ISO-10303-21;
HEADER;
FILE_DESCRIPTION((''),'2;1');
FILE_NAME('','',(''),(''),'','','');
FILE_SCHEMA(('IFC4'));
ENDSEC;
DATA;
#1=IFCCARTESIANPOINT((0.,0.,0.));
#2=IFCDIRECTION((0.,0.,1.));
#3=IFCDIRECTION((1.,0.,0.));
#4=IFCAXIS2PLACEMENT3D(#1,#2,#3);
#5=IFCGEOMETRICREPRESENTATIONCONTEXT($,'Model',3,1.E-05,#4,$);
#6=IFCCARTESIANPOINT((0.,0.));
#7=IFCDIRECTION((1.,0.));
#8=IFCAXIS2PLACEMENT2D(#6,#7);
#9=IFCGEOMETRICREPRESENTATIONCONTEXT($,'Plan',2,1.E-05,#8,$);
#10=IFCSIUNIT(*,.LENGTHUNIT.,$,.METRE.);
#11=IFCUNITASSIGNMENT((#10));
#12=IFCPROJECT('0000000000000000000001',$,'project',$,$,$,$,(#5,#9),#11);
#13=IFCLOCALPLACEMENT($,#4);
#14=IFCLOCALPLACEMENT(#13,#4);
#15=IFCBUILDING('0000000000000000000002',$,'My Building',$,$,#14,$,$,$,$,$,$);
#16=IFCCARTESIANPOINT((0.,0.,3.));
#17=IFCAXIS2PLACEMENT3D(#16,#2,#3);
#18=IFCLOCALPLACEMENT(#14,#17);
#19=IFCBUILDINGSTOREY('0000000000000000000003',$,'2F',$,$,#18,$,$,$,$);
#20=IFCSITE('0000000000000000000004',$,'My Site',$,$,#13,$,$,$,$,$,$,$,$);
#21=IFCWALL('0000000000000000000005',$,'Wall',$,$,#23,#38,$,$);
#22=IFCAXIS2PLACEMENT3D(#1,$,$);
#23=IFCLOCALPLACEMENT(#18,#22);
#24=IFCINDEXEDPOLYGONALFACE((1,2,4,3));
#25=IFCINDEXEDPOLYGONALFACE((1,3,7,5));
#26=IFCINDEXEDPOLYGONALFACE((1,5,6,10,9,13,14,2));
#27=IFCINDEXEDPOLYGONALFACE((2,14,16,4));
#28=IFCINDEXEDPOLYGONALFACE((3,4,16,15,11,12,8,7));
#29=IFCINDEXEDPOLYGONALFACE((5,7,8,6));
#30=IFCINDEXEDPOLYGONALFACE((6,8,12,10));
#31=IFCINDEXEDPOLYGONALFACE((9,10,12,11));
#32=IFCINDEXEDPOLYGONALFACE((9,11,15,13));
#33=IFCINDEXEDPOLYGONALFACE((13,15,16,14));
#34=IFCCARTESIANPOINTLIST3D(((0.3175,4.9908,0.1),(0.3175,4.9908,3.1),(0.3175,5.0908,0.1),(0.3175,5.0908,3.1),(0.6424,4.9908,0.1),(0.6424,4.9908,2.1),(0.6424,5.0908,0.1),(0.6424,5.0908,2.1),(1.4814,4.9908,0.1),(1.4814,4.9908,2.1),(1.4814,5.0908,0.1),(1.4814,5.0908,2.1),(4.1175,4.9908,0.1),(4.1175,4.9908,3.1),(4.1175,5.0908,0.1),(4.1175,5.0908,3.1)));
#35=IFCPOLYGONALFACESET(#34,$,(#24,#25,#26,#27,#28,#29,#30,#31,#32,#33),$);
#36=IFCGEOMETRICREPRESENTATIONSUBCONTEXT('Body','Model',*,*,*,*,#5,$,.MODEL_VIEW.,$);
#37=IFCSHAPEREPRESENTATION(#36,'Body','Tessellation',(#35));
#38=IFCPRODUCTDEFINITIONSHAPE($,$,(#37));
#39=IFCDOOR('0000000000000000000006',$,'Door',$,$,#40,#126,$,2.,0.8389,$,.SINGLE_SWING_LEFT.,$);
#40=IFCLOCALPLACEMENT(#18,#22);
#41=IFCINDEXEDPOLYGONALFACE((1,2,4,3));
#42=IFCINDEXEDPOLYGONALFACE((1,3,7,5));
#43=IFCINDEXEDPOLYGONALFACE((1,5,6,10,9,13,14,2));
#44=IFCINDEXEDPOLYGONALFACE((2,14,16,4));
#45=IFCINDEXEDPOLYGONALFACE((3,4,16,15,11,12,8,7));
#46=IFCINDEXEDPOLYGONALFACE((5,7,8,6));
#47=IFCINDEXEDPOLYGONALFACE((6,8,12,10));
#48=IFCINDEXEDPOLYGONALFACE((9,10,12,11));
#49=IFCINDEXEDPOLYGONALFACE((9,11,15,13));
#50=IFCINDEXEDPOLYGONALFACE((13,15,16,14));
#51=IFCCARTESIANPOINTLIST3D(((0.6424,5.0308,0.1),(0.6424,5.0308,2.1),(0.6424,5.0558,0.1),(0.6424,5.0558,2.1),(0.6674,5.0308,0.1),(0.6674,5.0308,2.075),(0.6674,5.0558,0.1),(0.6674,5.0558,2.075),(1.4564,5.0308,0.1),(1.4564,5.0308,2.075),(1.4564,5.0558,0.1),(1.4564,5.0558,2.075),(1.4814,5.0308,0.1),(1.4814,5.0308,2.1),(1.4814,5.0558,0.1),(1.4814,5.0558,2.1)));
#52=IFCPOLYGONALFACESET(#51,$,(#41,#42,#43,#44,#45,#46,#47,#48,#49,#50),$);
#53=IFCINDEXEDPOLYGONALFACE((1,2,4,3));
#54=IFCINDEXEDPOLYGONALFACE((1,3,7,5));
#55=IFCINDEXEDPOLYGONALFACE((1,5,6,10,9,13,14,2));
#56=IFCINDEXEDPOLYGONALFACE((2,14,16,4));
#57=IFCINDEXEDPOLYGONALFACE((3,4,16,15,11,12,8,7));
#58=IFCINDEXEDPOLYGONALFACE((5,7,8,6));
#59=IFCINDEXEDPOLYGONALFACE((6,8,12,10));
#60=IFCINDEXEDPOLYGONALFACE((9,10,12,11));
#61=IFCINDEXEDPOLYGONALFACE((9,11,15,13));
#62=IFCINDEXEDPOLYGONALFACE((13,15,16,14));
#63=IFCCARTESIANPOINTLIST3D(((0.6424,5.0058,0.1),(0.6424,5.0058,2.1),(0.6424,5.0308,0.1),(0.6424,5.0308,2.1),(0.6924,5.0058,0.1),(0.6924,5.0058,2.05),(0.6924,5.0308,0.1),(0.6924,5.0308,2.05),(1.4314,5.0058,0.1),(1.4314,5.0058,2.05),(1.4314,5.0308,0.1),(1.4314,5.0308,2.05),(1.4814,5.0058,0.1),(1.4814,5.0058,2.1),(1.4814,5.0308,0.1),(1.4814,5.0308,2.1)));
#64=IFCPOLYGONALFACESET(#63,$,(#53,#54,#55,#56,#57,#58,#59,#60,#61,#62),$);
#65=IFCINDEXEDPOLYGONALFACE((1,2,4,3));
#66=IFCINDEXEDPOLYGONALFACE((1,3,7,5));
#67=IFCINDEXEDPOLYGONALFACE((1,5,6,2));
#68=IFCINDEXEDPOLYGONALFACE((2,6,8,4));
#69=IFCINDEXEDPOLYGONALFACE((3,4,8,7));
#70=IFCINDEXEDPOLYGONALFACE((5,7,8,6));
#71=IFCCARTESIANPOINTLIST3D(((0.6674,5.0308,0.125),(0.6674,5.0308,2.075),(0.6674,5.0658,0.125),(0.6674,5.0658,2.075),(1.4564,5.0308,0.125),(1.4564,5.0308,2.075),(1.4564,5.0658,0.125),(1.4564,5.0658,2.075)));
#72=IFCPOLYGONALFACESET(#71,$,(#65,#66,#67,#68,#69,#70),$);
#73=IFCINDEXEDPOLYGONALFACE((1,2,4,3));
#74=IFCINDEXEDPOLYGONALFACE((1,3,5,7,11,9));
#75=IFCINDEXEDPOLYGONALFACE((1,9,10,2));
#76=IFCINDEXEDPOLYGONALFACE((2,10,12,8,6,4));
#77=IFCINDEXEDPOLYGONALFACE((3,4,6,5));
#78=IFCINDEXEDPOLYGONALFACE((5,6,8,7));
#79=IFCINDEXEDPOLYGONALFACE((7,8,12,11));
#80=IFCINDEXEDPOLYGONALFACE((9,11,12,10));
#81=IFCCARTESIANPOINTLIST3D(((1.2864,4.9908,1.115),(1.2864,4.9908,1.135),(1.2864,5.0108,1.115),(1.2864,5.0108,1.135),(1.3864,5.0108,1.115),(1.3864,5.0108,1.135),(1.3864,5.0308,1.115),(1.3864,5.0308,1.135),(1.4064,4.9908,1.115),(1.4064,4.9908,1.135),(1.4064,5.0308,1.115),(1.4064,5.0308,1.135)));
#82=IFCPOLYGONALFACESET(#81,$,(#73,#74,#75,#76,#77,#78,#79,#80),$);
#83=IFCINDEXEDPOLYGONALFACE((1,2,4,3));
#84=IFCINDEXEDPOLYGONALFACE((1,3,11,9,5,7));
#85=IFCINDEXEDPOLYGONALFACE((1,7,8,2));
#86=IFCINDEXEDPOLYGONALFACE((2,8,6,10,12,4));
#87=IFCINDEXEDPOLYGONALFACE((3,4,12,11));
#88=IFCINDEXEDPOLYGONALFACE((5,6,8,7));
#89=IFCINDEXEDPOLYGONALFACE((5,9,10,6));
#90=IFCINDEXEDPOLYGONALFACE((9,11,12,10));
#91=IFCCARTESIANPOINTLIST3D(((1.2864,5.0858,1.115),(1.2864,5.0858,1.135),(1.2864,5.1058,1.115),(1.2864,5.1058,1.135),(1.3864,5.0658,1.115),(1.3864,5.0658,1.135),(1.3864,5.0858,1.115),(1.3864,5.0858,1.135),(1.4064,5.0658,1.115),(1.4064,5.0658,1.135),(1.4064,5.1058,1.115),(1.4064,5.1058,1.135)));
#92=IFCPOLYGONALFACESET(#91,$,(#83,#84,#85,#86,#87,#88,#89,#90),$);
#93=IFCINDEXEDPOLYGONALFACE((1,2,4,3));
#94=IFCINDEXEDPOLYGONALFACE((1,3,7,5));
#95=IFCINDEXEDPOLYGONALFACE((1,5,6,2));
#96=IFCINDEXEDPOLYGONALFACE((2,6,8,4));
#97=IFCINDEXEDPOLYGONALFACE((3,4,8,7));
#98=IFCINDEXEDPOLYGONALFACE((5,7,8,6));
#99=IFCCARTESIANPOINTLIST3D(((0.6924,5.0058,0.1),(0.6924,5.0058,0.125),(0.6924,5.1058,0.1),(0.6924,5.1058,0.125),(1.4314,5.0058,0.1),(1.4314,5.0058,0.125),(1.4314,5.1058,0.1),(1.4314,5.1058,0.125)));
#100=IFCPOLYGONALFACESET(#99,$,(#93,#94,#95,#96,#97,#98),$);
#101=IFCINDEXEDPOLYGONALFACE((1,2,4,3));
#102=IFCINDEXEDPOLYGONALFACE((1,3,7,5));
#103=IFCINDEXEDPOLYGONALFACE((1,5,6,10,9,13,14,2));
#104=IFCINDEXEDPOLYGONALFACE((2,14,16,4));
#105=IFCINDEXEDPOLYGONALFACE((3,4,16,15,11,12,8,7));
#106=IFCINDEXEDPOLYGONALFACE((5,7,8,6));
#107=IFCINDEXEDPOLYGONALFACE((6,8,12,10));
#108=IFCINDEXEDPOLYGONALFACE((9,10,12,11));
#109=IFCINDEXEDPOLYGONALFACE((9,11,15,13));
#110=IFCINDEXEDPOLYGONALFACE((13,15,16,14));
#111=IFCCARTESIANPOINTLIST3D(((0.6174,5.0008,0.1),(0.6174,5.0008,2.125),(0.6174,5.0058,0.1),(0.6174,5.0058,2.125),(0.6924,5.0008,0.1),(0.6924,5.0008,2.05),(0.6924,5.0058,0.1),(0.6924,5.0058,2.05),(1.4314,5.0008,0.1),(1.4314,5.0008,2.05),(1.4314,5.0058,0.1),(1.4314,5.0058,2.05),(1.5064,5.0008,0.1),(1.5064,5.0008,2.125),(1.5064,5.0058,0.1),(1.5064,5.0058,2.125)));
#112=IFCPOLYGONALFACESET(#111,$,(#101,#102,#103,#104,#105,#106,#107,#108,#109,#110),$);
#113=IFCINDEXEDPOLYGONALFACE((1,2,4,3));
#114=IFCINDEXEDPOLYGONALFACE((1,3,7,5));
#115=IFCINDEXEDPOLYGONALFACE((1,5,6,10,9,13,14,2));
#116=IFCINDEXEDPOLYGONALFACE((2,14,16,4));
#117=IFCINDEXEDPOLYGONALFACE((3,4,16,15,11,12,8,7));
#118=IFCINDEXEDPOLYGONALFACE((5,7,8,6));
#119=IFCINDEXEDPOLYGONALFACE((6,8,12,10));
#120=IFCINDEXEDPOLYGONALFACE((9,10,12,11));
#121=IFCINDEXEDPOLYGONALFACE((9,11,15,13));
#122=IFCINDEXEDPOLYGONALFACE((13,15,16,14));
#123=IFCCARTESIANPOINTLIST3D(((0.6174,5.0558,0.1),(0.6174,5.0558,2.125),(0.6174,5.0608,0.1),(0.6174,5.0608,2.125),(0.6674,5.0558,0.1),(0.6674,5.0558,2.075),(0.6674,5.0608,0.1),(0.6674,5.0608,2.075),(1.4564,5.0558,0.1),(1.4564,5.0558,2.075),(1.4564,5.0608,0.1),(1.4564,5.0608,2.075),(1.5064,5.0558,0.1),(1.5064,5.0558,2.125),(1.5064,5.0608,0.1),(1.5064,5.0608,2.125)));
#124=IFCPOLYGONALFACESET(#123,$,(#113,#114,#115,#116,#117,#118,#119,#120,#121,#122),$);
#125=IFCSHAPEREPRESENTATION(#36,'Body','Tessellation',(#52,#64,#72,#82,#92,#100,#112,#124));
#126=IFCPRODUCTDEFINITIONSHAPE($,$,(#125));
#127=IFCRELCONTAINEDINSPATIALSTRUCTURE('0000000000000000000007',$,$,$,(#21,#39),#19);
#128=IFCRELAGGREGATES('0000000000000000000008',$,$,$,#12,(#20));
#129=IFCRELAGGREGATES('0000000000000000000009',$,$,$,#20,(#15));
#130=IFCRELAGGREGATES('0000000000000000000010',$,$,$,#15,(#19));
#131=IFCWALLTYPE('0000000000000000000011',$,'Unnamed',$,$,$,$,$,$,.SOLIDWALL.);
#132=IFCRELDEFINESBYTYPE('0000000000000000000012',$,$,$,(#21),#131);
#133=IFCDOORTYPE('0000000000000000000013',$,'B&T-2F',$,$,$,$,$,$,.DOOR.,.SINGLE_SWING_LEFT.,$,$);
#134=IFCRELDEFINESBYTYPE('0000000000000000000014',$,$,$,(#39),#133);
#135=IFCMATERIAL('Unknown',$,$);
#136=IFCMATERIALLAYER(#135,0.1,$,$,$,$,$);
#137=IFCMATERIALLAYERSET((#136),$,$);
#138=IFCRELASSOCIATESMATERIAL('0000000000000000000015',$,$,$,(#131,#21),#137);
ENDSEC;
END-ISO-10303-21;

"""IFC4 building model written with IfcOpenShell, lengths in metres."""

from ifc_helpers import new_model, entity, si_unit, frame, origin_with_axes, origin_2d_with_axis, place, context, subcontext, project, spatial, line, indexed_curve, outline, extrude, shape, source, transform, mapped, material, layer, layer_set, layer_usage, type_object, type_shapes, element, fill, save


model = new_model("IFC4")

# Units and contexts
model_context = context("Model", 3, precision=1e-05, world=origin_with_axes())
plan_context = context("Plan", 2, precision=1e-05, world=origin_2d_with_axis())
body_context_1 = subcontext(model_context, "Body", "Model", "MODEL_VIEW")
body_context_2 = subcontext(plan_context, "Body", "Plan", "PLAN_VIEW")
ifc_project = project(units=[si_unit("LENGTHUNIT", "METRE")], contexts=[model_context, plan_context])

# Site, building, storey
site_placement = place(None, origin_with_axes())
site = spatial("IfcSite", under=ifc_project, at=site_placement, Name="My Site")
building_placement = place(site_placement, origin_with_axes())
building = spatial("IfcBuilding", under=site, at=building_placement, Name="My Building")
storey_placement = place(building_placement, frame((0.0, 0.0, 3.0), z_axis=(0.0, 0.0, 1.0), x_axis=(1.0, 0.0, 0.0)))
storey = spatial("IfcBuildingStorey", under=building, at=storey_placement, Name="2F")

# Shared definitions
ifc_material = material(Name="Unknown")

# Shared definitions
ifc_layer_1 = layer(ifc_material, 0.1)
ifc_layer_set_1 = layer_set([ifc_layer_1])
wall_type = type_object("IfcWallType", Name="Unnamed", PredefinedType="SOLIDWALL", material=ifc_layer_set_1)

# Wall, opening, door
ifc_layer_usage_1 = layer_usage(ifc_layer_set_1, "AXIS2", "POSITIVE", 0.0)
wall_1_placement = place(storey_placement, frame((4.1175, 5.0908, 0.1), z_axis=(0.0, 0.0, 1.0), x_axis=(-1.0, 0.0, 0.0)))
wall_1 = element("IfcWall", 1, at=wall_1_placement, inside=storey, type_object=wall_type, material=ifc_layer_usage_1, Name="Wall", context=body_context_1, shape_type="SweptSolid", body=[
    extrude(outline(indexed_curve([(0.0, 0.0), (0.0, 0.1), (3.8, 0.1), (3.8, 0.0)], segments=[line(1, 2, 3, 4, 1)])), origin_with_axes(), (0.0, 0.0, 1.0), 3.0),
])
shared_shape_1 = source(origin_with_axes(), body_context_1, "Body", "SweptSolid", [
    extrude(outline(indexed_curve([(0.0, 0.0), (0.8389, 0.0), (0.8389, 2.0), (0.0, 2.0)], segments=[line(1, 2, 3, 4, 1)])), frame((0.0, -0.6, 0.0), z_axis=(0.0, -1.0, 0.0), x_axis=(1.0, 0.0, 0.0)), (0.0, 0.0, -1.0), 1.2),
])
opening_1_placement = place(wall_1_placement, frame((3.4751, 0.085, 0.0), z_axis=(0.0, 0.0, 1.0), x_axis=(-1.0, 0.0, 0.0)))
opening_1 = element("IfcOpeningElement", 2, at=opening_1_placement, cuts=wall_1, PredefinedType="OPENING", context=body_context_1, shape_type="MappedRepresentation", body=[
    mapped(shared_shape_1, transform((0.0, 0.0, 0.0), x_axis=(1.0, 0.0, 0.0), y_axis=(0.0, 1.0, 0.0), z_axis=(0.0, 0.0, 1.0), scale=1.0)),
])
door_type_1 = type_object("IfcDoorType", Name="B&T-2F", OperationType="SINGLE_SWING_LEFT", PredefinedType="DOOR")
shared_shape_2 = source(origin_with_axes(), body_context_1, "Body", "SweptSolid", [
    extrude(outline(indexed_curve([(0.0, 0.0), (0.0, 2.0), (0.8389, 2.0), (0.8389, 0.0), (0.8139, 0.0), (0.8139, 1.975), (0.025, 1.975), (0.025, 0.0)], segments=[line(1, 2, 3, 4, 5, 6, 7, 8, 1)])), frame((0.0, 0.025, 0.0), z_axis=(0.0, -1.0, 0.0), x_axis=(1.0, 0.0, 0.0)), (0.0, 0.0, -1.0), 0.025),
    extrude(outline(indexed_curve([(0.0, 0.0), (0.0, 2.0), (0.8389, 2.0), (0.8389, 0.0), (0.7889, 0.0), (0.7889, 1.95), (0.05, 1.95), (0.05, 0.0)], segments=[line(1, 2, 3, 4, 5, 6, 7, 8, 1)])), frame((0.0, 0.0, 0.0), z_axis=(0.0, -1.0, 0.0), x_axis=(1.0, 0.0, 0.0)), (0.0, 0.0, -1.0), 0.025),
    extrude(outline(indexed_curve([(0.0, 0.0), (0.7889, 0.0), (0.7889, 0.035), (0.0, 0.035)], segments=[line(1, 2, 3, 4, 1)])), frame((0.025, 0.025, 0.025), z_axis=(0.0, 0.0, 1.0), x_axis=(1.0, 0.0, 0.0)), (0.0, 0.0, 1.0), 1.95),
    extrude(outline(indexed_curve([(0.0, 0.0), (0.0, -0.04), (-0.12, -0.04), (-0.12, -0.02), (-0.02, -0.02), (-0.02, 0.0)], segments=[line(1, 2, 3, 4, 5, 6, 1)])), frame((0.7639, 0.025, 1.015), z_axis=(0.0, 0.0, 1.0), x_axis=(1.0, 0.0, 0.0)), (0.0, 0.0, 1.0), 0.02),
    extrude(outline(indexed_curve([(0.0, 0.0), (0.0, 0.04), (-0.12, 0.04), (-0.12, 0.02), (-0.02, 0.02), (-0.02, 0.0)], segments=[line(1, 2, 3, 4, 5, 6, 1)])), frame((0.7639, 0.06, 1.015), z_axis=(0.0, 0.0, 1.0), x_axis=(1.0, 0.0, 0.0)), (0.0, 0.0, 1.0), 0.02),
    extrude(outline(indexed_curve([(0.0, 0.0), (0.7389, 0.0), (0.7389, 0.1), (0.0, 0.1)], segments=[line(1, 2, 3, 4, 1)])), frame((0.05, 0.0, 0.0), z_axis=(0.0, 0.0, 1.0), x_axis=(1.0, 0.0, 0.0)), (0.0, 0.0, 1.0), 0.025),
    extrude(outline(indexed_curve([(0.0, 0.0), (0.0, 2.025), (0.8889, 2.025), (0.8889, 0.0), (0.8139, 0.0), (0.8139, 1.95), (0.075, 1.95), (0.075, 0.0)], segments=[line(1, 2, 3, 4, 5, 6, 7, 8, 1)])), frame((-0.025, -0.005, 0.0), z_axis=(0.0, -1.0, 0.0), x_axis=(1.0, 0.0, 0.0)), (0.0, 0.0, -1.0), 0.005),
    extrude(outline(indexed_curve([(0.0, 0.0), (0.0, 2.025), (0.8889, 2.025), (0.8889, 0.0), (0.8389, 0.0), (0.8389, 1.975), (0.05, 1.975), (0.05, 0.0)], segments=[line(1, 2, 3, 4, 5, 6, 7, 8, 1)])), frame((-0.025, 0.05, 0.0), z_axis=(0.0, -1.0, 0.0), x_axis=(1.0, 0.0, 0.0)), (0.0, 0.0, -1.0), 0.005),
])
shared_shape_3 = source(origin_with_axes(), body_context_2, "Body", "Curve2D", [
    entity("IfcIndexedPolyCurve", entity("IfcCartesianPointList2D", [[0.0, 0.0], [0.0, 0.05], [0.025, 0.05], [0.025, 0.025], [0.05, 0.025], [0.05, 0.0]]), [entity("IfcLineIndex", [1, 2, 3, 4, 5, 6, 1])]),
    entity("IfcIndexedPolyCurve", entity("IfcCartesianPointList2D", [[0.8389, 0.0], [0.8389, 0.05], [0.8139, 0.05], [0.8139, 0.025], [0.7889, 0.025], [0.7889, 0.0]]), [entity("IfcLineIndex", [1, 2, 3, 4, 5, 6, 1])]),
    entity("IfcTrimmedCurve", entity("IfcEllipse", entity("IfcAxis2Placement2D", entity("IfcCartesianPoint", [0.06, 0.05]), entity("IfcDirection", [1.0, 0.0])), 0.7539, 0.7889), [entity("IfcCartesianPoint", [0.8139, 0.05])], [entity("IfcCartesianPoint", [0.06, 0.8389])], True, "CARTESIAN"),
    entity("IfcIndexedPolyCurve", entity("IfcCartesianPointList2D", [[0.025, 0.05], [0.06, 0.05], [0.06, 0.8389], [0.025, 0.8389]]), [entity("IfcLineIndex", [1, 2, 3, 4, 1])]),
])
type_shapes(door_type_1, [shared_shape_2, shared_shape_3])
door_1_placement = place(opening_1_placement, frame((0.0, 0.0, 0.0), z_axis=(0.0, 0.0, 1.0), x_axis=(1.0, 0.0, 0.0)))
door_1 = element("IfcDoor", 3, at=door_1_placement, inside=storey, type_object=door_type_1, Name="Door", OperationType="SINGLE_SWING_LEFT", OverallHeight=2.0, OverallWidth=0.8389, shapes=[
    shape(body_context_1, "Body", "MappedRepresentation", [mapped(shared_shape_2, transform((0.0, 0.0, 0.0), x_axis=(1.0, 0.0, 0.0), y_axis=(0.0, 1.0, 0.0), z_axis=(0.0, 0.0, 1.0), scale=1.0))]),
    shape(body_context_2, "Body", "MappedRepresentation", [mapped(shared_shape_3, transform((0.0, 0.0, 0.0), x_axis=(1.0, 0.0, 0.0), y_axis=(0.0, 1.0, 0.0), z_axis=(0.0, 0.0, 1.0), scale=1.0))]),
])
fill(opening_1, door_1)

save(model, "model.ifc")
